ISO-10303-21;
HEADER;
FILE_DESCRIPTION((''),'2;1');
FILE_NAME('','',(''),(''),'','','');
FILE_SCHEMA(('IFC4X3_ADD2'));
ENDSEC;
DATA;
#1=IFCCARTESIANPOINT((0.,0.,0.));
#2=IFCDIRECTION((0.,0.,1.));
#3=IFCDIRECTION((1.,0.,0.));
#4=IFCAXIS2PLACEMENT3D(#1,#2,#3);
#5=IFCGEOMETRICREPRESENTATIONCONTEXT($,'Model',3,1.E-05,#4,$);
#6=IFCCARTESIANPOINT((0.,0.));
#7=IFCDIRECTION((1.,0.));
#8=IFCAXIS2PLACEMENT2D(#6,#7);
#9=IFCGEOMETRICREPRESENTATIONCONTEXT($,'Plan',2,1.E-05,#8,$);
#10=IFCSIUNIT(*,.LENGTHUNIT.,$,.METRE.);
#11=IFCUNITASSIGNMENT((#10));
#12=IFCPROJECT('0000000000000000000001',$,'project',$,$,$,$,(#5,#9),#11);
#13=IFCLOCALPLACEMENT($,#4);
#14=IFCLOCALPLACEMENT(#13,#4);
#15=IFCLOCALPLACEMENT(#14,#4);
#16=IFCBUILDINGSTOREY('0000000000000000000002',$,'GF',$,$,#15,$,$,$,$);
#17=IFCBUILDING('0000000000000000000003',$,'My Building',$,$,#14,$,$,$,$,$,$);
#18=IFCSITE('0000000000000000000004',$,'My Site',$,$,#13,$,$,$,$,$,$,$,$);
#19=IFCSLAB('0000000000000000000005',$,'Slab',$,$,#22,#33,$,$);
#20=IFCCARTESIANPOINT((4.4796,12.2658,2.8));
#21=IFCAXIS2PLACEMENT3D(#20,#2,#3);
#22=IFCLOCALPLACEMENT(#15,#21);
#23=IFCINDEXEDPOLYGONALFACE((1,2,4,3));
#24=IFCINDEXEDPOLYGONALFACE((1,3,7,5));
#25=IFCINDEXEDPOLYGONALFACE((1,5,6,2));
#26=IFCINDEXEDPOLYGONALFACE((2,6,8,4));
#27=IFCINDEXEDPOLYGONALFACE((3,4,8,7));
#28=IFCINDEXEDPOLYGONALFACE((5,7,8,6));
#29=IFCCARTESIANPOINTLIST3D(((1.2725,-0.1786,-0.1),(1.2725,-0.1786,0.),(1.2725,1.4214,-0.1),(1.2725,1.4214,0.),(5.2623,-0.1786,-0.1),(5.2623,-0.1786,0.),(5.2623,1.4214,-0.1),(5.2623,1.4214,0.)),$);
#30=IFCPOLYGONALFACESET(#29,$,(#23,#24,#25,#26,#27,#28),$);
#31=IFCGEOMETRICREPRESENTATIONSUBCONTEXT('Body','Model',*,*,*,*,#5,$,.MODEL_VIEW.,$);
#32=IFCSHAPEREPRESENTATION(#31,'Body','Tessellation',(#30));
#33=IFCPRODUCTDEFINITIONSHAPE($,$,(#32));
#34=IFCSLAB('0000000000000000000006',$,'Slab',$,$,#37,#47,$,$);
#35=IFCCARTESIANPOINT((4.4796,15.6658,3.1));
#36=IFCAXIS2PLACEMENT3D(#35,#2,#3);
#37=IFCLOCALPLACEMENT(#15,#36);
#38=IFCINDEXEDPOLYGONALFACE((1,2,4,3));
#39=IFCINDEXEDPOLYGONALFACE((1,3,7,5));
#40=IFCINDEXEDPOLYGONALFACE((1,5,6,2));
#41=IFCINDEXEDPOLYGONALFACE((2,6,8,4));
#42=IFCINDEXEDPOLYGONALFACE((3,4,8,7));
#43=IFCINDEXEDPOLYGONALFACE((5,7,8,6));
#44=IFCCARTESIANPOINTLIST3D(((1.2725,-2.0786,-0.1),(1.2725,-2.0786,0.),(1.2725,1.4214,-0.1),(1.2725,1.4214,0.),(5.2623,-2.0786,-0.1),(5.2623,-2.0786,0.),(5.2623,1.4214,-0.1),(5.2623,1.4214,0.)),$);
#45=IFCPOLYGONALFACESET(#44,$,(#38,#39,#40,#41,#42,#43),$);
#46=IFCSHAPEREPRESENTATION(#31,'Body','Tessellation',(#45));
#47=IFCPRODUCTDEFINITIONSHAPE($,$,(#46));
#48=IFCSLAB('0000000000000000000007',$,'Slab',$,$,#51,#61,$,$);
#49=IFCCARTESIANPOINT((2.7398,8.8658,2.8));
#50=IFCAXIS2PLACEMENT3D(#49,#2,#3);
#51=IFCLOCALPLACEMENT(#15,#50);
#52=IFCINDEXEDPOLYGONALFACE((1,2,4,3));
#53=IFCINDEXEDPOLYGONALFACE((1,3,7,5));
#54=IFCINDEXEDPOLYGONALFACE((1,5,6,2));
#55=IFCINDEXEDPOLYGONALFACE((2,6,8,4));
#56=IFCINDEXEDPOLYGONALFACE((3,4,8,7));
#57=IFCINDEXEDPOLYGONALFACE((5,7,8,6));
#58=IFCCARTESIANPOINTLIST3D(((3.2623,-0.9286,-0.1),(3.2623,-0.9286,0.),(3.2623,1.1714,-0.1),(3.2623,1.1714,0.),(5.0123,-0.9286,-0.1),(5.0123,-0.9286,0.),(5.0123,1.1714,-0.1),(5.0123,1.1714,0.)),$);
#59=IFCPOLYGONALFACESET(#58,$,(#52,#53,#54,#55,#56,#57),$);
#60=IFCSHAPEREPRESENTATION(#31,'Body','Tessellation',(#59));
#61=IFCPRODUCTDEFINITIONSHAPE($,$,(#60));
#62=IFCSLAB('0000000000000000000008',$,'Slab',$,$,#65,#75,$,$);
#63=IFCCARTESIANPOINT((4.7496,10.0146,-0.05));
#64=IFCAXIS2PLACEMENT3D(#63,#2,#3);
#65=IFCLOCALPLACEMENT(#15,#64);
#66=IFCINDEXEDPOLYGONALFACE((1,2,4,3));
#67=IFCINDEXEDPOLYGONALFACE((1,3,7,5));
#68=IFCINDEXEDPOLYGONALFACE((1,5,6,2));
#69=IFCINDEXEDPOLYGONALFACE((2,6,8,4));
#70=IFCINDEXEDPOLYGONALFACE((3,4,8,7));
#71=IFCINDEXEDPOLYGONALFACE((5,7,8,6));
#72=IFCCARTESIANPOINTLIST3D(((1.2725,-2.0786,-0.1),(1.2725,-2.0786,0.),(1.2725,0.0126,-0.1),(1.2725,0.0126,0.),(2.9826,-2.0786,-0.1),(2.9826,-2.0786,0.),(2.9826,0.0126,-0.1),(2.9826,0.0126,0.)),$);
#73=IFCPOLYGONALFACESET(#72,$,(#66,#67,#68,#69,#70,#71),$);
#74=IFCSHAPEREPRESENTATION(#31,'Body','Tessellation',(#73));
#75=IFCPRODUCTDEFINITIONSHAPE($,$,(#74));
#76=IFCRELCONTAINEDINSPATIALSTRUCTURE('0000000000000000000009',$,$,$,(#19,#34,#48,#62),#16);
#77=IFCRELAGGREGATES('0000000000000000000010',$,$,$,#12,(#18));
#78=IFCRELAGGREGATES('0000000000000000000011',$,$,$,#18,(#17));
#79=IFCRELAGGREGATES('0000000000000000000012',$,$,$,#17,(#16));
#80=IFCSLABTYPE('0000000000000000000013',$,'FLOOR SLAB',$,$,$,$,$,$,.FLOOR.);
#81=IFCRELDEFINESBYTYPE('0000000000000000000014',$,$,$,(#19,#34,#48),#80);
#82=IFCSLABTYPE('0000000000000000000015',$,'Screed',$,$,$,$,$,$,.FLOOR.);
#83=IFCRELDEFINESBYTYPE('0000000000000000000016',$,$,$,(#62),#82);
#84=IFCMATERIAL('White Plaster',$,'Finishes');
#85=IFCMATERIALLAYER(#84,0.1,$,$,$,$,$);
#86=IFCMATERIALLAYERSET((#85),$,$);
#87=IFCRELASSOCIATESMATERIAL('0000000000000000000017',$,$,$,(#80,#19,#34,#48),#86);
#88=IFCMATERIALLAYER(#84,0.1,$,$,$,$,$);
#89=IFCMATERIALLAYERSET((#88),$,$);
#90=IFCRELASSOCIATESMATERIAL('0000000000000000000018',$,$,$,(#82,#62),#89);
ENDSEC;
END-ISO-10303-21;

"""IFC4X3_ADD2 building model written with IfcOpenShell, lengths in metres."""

from ifc_helpers import new_model, si_unit, frame, origin_with_axes, origin_2d_with_axis, place, context, subcontext, project, spatial, indexed_curve, outline, extrude, material, layer, layer_set, layer_usage, type_object, element, save


model = new_model("IFC4X3_ADD2")

# Units and contexts
model_context = context("Model", 3, precision=1e-05, world=origin_with_axes())
plan_context = context("Plan", 2, precision=1e-05, world=origin_2d_with_axis())
body_context_1 = subcontext(model_context, "Body", "Model", "MODEL_VIEW")
ifc_project = project(units=[si_unit("LENGTHUNIT", "METRE")], contexts=[model_context, plan_context])

# Site, building, storey
site_placement = place(None, origin_with_axes())
site = spatial("IfcSite", under=ifc_project, at=site_placement, Name="My Site")
building_placement = place(site_placement, origin_with_axes())
building = spatial("IfcBuilding", under=site, at=building_placement, Name="My Building")
storey_placement = place(building_placement, origin_with_axes())
storey = spatial("IfcBuildingStorey", under=building, at=storey_placement, Name="GF")

# Slabs
ifc_material_1 = material(Name="White Plaster", Category="Finishes")
ifc_layer_1 = layer(ifc_material_1, 0.1)
ifc_layer_set_1 = layer_set([ifc_layer_1])
ifc_layer_usage_1 = layer_usage(ifc_layer_set_1, "AXIS3", "POSITIVE", -0.1)
slab_type_1 = type_object("IfcSlabType", Name="FLOOR SLAB", PredefinedType="FLOOR", material=ifc_layer_set_1)
slab_1_placement = place(storey_placement, frame((4.4796, 12.2658, 2.8), z_axis=(0.0, 0.0, 1.0), x_axis=(1.0, 0.0, 0.0)))
element("IfcSlab", 1, at=slab_1_placement, inside=storey, type_object=slab_type_1, material=ifc_layer_usage_1, Name="Slab", context=body_context_1, shape_type="SweptSolid", body=[
    extrude(outline(indexed_curve([(1.2725, -0.1786), (5.2623, -0.1786), (5.2623, 1.4214), (1.2725, 1.4214), (1.2725, -0.1786)])), frame((0.0, 0.0, -0.1), z_axis=(0.0, 0.0, 1.0), x_axis=(1.0, 0.0, 0.0)), (0.0, 0.0, 1.0), 0.1),
])
ifc_layer_usage_2 = layer_usage(ifc_layer_set_1, "AXIS3", "POSITIVE", -0.1)
slab_2_placement = place(storey_placement, frame((4.4796, 15.6658, 3.1), z_axis=(0.0, 0.0, 1.0), x_axis=(1.0, 0.0, 0.0)))
element("IfcSlab", 2, at=slab_2_placement, inside=storey, type_object=slab_type_1, material=ifc_layer_usage_2, Name="Slab", context=body_context_1, shape_type="SweptSolid", body=[
    extrude(outline(indexed_curve([(1.2725, -2.0786), (5.2623, -2.0786), (5.2623, 1.4214), (1.2725, 1.4214), (1.2725, -2.0786)])), frame((0.0, 0.0, -0.1), z_axis=(0.0, 0.0, 1.0), x_axis=(1.0, 0.0, 0.0)), (0.0, 0.0, 1.0), 0.1),
])
ifc_layer_usage_3 = layer_usage(ifc_layer_set_1, "AXIS3", "POSITIVE", -0.1)
slab_3_placement = place(storey_placement, frame((2.7398, 8.8658, 2.8), z_axis=(0.0, 0.0, 1.0), x_axis=(1.0, 0.0, 0.0)))
element("IfcSlab", 3, at=slab_3_placement, inside=storey, type_object=slab_type_1, material=ifc_layer_usage_3, Name="Slab", context=body_context_1, shape_type="SweptSolid", body=[
    extrude(outline(indexed_curve([(3.2623, 1.1714), (5.0123, 1.1714), (5.0123, -0.9286), (3.2623, -0.9286), (3.2623, 1.1714)])), frame((0.0, 0.0, -0.1), z_axis=(0.0, 0.0, 1.0), x_axis=(1.0, 0.0, 0.0)), (0.0, 0.0, 1.0), 0.1),
])
ifc_layer_2 = layer(ifc_material_1, 0.1)
ifc_layer_set_2 = layer_set([ifc_layer_2])
ifc_layer_usage_4 = layer_usage(ifc_layer_set_2, "AXIS3", "POSITIVE", -0.1)
slab_type_2 = type_object("IfcSlabType", Name="Screed", PredefinedType="FLOOR", material=ifc_layer_set_2)
slab_4_placement = place(storey_placement, frame((4.7496, 10.0146, -0.05), z_axis=(0.0, 0.0, 1.0), x_axis=(1.0, 0.0, 0.0)))
element("IfcSlab", 4, at=slab_4_placement, inside=storey, type_object=slab_type_2, material=ifc_layer_usage_4, Name="Slab", context=body_context_1, shape_type="SweptSolid", body=[
    extrude(outline(indexed_curve([(1.2725, 0.0126), (2.9826, 0.0126), (2.9826, -2.0786), (1.2725, -2.0786), (1.2725, 0.0126)])), frame((0.0, 0.0, -0.1), z_axis=(0.0, 0.0, 1.0), x_axis=(1.0, 0.0, 0.0)), (0.0, 0.0, 1.0), 0.1),
])

save(model, "model.ifc")
